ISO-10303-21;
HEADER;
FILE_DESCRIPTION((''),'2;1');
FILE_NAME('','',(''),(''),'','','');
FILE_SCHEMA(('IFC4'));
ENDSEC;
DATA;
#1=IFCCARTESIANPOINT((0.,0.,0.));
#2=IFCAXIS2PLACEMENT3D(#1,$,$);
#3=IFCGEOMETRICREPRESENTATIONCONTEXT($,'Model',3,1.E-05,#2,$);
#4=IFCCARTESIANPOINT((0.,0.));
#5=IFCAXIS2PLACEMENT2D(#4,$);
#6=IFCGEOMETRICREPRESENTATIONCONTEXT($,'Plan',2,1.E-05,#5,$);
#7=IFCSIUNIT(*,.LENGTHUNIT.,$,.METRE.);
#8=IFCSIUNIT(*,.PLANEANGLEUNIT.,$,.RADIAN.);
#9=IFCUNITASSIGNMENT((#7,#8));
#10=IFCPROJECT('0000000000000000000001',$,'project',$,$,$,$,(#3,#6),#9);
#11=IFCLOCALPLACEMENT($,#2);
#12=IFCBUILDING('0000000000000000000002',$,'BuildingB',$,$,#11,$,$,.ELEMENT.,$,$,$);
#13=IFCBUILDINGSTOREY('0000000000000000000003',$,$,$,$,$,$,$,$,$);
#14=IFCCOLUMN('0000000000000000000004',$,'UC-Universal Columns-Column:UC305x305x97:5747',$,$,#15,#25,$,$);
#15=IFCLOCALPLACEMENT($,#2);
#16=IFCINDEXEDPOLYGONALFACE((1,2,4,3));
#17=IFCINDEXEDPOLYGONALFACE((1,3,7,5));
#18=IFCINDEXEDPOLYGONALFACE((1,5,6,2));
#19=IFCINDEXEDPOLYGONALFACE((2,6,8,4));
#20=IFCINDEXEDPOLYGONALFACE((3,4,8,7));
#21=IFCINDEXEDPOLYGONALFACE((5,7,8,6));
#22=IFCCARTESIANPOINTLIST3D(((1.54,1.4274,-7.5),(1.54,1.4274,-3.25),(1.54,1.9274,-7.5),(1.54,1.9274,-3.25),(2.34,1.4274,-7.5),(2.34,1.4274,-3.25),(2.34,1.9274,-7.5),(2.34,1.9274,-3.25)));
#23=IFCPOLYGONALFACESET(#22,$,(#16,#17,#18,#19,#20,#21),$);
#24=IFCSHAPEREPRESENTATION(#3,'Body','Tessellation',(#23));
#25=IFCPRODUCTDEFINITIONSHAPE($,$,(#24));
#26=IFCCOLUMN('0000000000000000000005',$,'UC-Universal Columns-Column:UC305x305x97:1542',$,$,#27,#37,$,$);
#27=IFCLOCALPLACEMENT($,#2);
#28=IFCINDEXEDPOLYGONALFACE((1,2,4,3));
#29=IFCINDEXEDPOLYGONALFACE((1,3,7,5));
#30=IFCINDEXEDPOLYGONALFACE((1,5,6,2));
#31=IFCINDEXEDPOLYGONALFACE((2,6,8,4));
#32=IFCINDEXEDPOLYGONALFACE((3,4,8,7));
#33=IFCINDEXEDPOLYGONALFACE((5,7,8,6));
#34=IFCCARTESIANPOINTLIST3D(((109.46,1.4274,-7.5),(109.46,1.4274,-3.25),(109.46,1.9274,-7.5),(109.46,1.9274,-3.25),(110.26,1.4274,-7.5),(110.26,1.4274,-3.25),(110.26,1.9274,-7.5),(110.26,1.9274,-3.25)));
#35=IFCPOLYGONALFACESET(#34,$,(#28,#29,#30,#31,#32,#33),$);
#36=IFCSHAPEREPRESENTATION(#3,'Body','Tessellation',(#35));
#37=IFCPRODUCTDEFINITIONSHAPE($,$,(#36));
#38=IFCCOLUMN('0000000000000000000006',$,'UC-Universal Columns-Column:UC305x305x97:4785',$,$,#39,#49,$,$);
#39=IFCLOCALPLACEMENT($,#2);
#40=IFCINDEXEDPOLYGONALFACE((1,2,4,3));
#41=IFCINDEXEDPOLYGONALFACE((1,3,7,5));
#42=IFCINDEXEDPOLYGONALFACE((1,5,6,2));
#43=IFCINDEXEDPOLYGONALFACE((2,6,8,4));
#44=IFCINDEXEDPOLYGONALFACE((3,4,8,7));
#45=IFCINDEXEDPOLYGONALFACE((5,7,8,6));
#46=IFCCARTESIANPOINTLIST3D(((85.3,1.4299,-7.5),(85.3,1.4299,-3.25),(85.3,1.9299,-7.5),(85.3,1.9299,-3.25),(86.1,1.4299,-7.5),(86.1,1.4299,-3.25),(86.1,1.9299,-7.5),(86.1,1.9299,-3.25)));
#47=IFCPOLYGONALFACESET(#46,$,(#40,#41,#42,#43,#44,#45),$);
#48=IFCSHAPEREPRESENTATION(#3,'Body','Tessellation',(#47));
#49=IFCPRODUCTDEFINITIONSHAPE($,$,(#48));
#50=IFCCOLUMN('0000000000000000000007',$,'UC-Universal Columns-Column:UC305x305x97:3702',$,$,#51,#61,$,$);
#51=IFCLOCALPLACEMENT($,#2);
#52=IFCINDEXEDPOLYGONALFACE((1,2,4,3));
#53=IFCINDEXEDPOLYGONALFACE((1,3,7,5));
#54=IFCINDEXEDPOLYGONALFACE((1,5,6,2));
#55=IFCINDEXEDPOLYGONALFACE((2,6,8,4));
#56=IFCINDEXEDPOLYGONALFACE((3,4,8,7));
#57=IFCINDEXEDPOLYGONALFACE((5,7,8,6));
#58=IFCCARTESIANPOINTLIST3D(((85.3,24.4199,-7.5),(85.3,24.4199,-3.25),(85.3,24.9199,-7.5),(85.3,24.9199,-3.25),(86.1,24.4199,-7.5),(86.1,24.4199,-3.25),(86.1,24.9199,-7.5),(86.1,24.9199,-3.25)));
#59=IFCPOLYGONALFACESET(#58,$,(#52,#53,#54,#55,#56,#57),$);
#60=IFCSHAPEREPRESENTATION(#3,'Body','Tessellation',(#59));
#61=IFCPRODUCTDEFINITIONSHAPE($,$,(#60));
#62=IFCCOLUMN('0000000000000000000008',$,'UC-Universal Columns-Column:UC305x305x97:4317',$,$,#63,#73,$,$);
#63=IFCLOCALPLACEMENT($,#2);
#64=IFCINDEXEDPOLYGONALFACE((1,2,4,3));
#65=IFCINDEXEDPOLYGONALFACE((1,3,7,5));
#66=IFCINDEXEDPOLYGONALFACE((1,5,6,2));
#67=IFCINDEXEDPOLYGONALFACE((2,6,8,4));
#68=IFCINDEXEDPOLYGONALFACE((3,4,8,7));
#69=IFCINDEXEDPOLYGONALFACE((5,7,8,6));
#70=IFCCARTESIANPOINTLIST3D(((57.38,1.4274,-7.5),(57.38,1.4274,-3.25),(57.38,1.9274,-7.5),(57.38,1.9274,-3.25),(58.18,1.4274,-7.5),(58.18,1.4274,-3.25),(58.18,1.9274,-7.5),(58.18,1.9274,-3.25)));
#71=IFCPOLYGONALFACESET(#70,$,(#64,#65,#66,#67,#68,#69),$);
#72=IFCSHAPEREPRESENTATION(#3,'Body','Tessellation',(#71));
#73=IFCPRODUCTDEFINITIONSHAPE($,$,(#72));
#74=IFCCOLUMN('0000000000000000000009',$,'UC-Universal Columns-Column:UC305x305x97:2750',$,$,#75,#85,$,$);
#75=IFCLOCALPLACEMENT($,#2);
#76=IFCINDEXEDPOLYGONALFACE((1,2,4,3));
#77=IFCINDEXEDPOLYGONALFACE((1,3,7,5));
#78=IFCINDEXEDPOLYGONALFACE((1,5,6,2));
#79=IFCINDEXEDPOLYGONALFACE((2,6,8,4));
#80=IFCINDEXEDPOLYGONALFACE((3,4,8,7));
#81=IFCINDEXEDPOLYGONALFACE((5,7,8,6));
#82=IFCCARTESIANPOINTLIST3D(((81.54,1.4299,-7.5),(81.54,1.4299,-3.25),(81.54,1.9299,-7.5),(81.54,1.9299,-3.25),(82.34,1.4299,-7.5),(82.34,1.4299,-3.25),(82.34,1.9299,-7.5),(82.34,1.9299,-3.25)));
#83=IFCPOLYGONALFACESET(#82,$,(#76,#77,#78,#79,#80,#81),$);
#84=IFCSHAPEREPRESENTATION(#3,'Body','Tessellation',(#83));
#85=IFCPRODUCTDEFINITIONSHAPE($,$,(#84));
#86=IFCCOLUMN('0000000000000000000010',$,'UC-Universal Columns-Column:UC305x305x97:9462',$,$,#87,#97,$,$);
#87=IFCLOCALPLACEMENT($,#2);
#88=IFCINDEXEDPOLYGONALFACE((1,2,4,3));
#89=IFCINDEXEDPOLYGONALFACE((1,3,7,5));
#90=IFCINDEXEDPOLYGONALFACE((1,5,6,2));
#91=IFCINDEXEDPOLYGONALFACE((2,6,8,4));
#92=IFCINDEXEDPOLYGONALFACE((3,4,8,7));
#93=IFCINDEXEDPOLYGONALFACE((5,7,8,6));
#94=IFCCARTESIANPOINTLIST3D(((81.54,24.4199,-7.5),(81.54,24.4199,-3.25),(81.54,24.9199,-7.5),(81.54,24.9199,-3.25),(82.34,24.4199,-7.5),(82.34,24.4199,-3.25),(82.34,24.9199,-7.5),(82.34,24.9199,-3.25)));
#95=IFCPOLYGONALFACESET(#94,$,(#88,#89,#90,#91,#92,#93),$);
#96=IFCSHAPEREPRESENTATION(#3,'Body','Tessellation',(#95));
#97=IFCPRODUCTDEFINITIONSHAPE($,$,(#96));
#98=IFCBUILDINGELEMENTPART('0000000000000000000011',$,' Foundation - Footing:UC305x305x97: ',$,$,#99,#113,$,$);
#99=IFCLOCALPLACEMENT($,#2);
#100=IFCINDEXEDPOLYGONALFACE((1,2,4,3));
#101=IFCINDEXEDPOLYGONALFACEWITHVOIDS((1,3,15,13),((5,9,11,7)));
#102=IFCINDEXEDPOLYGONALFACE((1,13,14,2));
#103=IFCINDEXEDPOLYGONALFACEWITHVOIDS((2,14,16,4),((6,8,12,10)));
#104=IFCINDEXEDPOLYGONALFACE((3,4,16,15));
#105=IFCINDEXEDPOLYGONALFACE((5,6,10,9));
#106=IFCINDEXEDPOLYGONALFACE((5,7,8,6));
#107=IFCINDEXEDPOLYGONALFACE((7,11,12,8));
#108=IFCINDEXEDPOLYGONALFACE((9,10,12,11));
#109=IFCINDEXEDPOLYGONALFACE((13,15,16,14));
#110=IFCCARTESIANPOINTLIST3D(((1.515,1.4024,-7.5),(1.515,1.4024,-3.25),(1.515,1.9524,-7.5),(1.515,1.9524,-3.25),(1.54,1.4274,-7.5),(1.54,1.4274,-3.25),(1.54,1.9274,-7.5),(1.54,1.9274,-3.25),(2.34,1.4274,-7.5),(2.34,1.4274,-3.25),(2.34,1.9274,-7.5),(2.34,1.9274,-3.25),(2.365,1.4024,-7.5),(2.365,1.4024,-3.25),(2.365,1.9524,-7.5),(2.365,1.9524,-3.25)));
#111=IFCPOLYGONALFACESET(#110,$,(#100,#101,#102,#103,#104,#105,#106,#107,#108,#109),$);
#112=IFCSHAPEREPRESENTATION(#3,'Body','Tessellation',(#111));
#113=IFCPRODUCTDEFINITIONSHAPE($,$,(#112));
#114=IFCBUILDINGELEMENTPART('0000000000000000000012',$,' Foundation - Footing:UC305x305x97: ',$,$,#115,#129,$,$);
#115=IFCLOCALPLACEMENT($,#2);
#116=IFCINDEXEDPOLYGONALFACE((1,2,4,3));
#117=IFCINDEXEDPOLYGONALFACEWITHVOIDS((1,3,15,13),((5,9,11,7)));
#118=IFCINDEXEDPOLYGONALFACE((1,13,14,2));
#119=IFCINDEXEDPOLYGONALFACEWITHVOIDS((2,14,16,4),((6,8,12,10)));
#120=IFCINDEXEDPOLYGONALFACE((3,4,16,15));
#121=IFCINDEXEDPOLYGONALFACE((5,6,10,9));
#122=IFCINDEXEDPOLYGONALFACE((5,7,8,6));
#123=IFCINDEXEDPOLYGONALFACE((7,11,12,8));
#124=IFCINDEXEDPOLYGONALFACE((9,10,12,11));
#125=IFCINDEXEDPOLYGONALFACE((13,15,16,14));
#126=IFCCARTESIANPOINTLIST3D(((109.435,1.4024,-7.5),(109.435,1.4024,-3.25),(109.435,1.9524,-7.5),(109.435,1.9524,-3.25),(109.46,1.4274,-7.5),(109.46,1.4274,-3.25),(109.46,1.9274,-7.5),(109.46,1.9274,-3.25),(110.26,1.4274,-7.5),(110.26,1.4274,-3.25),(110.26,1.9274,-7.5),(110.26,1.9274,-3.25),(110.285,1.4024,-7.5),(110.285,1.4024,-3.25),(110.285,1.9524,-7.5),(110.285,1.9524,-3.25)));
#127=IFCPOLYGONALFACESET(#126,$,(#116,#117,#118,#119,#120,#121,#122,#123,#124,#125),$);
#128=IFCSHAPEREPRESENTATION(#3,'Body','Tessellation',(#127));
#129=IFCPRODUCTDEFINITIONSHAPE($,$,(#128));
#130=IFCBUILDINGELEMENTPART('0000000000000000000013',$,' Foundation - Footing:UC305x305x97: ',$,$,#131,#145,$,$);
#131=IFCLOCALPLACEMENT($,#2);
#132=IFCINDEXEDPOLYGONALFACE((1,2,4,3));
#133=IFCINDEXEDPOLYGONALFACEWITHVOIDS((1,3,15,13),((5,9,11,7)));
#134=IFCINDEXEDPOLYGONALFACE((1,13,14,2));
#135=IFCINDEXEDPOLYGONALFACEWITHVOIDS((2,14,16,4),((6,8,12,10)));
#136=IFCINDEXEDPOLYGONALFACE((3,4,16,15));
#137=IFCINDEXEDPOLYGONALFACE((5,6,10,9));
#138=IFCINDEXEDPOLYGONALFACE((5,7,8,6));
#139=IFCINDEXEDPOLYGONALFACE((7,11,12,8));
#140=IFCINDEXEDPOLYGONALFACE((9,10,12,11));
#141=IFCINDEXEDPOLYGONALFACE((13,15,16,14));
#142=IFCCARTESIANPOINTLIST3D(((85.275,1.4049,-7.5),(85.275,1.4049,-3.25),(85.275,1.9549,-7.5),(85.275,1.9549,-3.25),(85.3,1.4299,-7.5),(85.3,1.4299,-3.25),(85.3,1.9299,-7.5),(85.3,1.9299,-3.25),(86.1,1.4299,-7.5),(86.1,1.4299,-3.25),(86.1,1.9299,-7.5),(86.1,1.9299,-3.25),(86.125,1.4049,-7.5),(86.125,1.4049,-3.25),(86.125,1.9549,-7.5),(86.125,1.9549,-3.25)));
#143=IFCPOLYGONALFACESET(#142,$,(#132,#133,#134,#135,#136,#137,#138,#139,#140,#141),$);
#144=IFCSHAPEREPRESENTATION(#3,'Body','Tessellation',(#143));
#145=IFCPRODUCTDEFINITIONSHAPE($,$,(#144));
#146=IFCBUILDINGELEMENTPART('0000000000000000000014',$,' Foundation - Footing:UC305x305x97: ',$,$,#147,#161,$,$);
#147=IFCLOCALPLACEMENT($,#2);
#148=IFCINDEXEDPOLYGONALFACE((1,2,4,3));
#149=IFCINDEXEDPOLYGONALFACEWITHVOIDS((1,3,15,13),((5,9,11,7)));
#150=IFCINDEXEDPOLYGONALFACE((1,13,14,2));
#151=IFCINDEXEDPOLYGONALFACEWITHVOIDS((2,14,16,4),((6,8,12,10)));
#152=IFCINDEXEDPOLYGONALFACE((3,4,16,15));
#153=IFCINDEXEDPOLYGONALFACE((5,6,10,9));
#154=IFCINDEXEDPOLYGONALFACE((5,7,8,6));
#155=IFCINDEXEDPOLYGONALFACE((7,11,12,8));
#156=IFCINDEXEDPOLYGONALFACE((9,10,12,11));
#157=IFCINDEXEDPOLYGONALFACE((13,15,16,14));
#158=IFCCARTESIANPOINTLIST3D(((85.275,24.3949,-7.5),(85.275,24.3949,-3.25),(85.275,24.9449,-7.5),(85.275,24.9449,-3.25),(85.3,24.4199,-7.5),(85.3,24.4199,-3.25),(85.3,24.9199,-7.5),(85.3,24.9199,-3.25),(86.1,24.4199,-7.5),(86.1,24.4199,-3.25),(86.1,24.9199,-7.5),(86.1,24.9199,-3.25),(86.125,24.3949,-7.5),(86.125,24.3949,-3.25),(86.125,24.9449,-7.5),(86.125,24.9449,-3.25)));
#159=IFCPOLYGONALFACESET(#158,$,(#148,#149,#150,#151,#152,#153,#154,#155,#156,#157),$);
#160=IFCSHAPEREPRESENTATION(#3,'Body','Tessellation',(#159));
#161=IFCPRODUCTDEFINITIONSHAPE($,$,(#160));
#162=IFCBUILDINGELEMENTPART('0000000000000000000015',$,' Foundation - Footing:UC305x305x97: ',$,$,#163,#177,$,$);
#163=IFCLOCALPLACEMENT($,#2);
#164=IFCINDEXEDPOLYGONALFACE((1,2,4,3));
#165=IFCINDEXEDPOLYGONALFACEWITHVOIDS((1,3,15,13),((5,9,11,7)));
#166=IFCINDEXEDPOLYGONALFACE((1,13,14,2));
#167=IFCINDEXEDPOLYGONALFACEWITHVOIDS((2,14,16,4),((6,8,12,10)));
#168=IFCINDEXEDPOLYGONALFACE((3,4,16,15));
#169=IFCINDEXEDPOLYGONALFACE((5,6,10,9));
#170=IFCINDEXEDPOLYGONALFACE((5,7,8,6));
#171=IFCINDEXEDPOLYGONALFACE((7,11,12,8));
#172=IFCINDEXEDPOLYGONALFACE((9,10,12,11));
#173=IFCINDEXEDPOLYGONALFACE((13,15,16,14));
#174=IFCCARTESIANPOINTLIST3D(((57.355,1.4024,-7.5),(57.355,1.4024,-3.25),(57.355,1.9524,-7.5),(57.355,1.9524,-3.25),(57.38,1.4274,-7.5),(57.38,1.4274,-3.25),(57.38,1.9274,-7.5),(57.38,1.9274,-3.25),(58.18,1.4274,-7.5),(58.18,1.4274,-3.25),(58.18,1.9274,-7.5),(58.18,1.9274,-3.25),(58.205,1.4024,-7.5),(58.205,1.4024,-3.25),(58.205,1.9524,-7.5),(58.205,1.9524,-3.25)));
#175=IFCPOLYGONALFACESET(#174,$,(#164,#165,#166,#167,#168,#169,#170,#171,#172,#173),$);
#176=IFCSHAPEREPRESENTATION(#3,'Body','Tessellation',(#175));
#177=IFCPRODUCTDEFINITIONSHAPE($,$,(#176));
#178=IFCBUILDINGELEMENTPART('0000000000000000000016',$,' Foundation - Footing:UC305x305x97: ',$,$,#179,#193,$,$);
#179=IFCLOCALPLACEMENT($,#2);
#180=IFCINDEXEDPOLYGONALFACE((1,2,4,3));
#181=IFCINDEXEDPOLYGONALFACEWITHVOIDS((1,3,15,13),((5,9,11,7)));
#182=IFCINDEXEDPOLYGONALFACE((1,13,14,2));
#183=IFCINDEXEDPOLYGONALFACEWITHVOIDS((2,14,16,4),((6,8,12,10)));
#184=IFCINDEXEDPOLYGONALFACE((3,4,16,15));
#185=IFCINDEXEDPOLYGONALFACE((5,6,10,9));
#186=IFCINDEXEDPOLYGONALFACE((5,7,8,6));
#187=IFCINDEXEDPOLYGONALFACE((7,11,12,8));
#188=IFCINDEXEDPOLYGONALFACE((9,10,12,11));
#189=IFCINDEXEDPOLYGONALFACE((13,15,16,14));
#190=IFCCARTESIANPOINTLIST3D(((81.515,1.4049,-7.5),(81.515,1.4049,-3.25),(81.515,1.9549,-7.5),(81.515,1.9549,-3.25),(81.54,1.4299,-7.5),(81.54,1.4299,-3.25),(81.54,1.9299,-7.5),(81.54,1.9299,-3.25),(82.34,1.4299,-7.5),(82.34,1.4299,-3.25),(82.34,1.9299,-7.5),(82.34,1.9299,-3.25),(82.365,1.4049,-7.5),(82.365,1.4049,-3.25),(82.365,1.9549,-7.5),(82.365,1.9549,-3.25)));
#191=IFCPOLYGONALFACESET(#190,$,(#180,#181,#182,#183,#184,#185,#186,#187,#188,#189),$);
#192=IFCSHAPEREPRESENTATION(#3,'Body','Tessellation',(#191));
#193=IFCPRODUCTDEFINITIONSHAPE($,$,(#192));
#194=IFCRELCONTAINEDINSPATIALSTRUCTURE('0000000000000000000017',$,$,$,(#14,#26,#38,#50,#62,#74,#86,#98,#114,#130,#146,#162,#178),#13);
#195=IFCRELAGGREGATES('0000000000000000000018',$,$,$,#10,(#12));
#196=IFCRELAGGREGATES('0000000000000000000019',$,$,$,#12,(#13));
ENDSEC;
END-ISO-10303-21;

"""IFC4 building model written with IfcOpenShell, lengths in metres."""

from ifc_helpers import new_model, si_unit, origin, origin_2d, place, context, project, spatial, polyline, outline, extrude, element, save


model = new_model("IFC4")

# Units and contexts
model_context = context("Model", 3, precision=1e-05, world=origin())
plan_context = context("Plan", 2, precision=1e-05, world=origin_2d())
ifc_project = project(units=[si_unit("LENGTHUNIT", "METRE"), si_unit("PLANEANGLEUNIT", "RADIAN")], contexts=[model_context, plan_context])

# Building, storey
building_placement = place(None, origin())
building = spatial("IfcBuilding", under=ifc_project, at=building_placement, Name="BuildingB", CompositionType="ELEMENT")
storey = spatial("IfcBuildingStorey", under=building)

# Columns
element("IfcColumn", 1, inside=storey, Name="UC-Universal Columns-Column:UC305x305x97:5747", context=model_context, shape_type="SweptSolid", body=[
    extrude(outline(polyline([(1.54, 1.4274, -7.5), (2.34, 1.4274, -7.5), (2.34, 1.9274, -7.5), (1.54, 1.9274, -7.5), (1.54, 1.4274, -7.5)])), None, (0.0, 0.0, 1.0), 4.25),
])
element("IfcColumn", 2, inside=storey, Name="UC-Universal Columns-Column:UC305x305x97:1542", context=model_context, shape_type="SweptSolid", body=[
    extrude(outline(polyline([(110.26, 1.4274, -7.5), (109.46, 1.4274, -7.5), (109.46, 1.9274, -7.5), (110.26, 1.9274, -7.5), (110.26, 1.4274, -7.5)])), None, (0.0, 0.0, 1.0), 4.25),
])
element("IfcColumn", 3, inside=storey, Name="UC-Universal Columns-Column:UC305x305x97:4785", context=model_context, shape_type="SweptSolid", body=[
    extrude(outline(polyline([(86.1, 1.4299, -7.5), (85.3, 1.4299, -7.5), (85.3, 1.9299, -7.5), (86.1, 1.9299, -7.5), (86.1, 1.4299, -7.5)])), None, (0.0, 0.0, 1.0), 4.25),
])
element("IfcColumn", 4, inside=storey, Name="UC-Universal Columns-Column:UC305x305x97:3702", context=model_context, shape_type="SweptSolid", body=[
    extrude(outline(polyline([(86.1, 24.4199, -7.5), (85.3, 24.4199, -7.5), (85.3, 24.9199, -7.5), (86.1, 24.9199, -7.5), (86.1, 24.4199, -7.5)])), None, (0.0, 0.0, 1.0), 4.25),
])
element("IfcColumn", 5, inside=storey, Name="UC-Universal Columns-Column:UC305x305x97:4317", context=model_context, shape_type="SweptSolid", body=[
    extrude(outline(polyline([(57.38, 1.4274, -7.5), (58.18, 1.4274, -7.5), (58.18, 1.9274, -7.5), (57.38, 1.9274, -7.5), (57.38, 1.4274, -7.5)])), None, (0.0, 0.0, 1.0), 4.25),
])
element("IfcColumn", 6, inside=storey, Name="UC-Universal Columns-Column:UC305x305x97:2750", context=model_context, shape_type="SweptSolid", body=[
    extrude(outline(polyline([(81.54, 1.4299, -7.5), (82.34, 1.4299, -7.5), (82.34, 1.9299, -7.5), (81.54, 1.9299, -7.5), (81.54, 1.4299, -7.5)])), None, (0.0, 0.0, 1.0), 4.25),
])
element("IfcColumn", 7, inside=storey, Name="UC-Universal Columns-Column:UC305x305x97:9462", context=model_context, shape_type="SweptSolid", body=[
    extrude(outline(polyline([(81.54, 24.4199, -7.5), (82.34, 24.4199, -7.5), (82.34, 24.9199, -7.5), (81.54, 24.9199, -7.5), (81.54, 24.4199, -7.5)])), None, (0.0, 0.0, 1.0), 4.25),
])

# Building element parts, openings
building_element_part_1 = element("IfcBuildingElementPart", 8, inside=storey, Name=" Foundation - Footing:UC305x305x97: ", context=model_context, shape_type="SweptSolid", body=[
    extrude(outline(polyline([(1.515, 1.4024, -7.5), (2.365, 1.4024, -7.5), (2.365, 1.9524, -7.5), (1.515, 1.9524, -7.5), (1.515, 1.4024, -7.5)])), None, (0.0, 0.0, 1.0), 4.25),
])
element("IfcOpeningElement", 9, inside=storey, cuts=building_element_part_1, context=model_context, shape_type="SweptSolid", body=[
    extrude(outline(polyline([(1.54, 1.4274, -7.5), (2.34, 1.4274, -7.5), (2.34, 1.9274, -7.5), (1.54, 1.9274, -7.5), (1.54, 1.4274, -7.5)])), None, (0.0, 0.0, 1.0), 4.25),
])
building_element_part_2 = element("IfcBuildingElementPart", 10, inside=storey, Name=" Foundation - Footing:UC305x305x97: ", context=model_context, shape_type="SweptSolid", body=[
    extrude(outline(polyline([(110.285, 1.4024, -7.5), (109.435, 1.4024, -7.5), (109.435, 1.9524, -7.5), (110.285, 1.9524, -7.5), (110.285, 1.4024, -7.5)])), None, (0.0, 0.0, 1.0), 4.25),
])
element("IfcOpeningElement", 11, inside=storey, cuts=building_element_part_2, context=model_context, shape_type="SweptSolid", body=[
    extrude(outline(polyline([(110.26, 1.4274, -7.5), (109.46, 1.4274, -7.5), (109.46, 1.9274, -7.5), (110.26, 1.9274, -7.5), (110.26, 1.4274, -7.5)])), None, (0.0, 0.0, 1.0), 4.25),
])
building_element_part_3 = element("IfcBuildingElementPart", 12, inside=storey, Name=" Foundation - Footing:UC305x305x97: ", context=model_context, shape_type="SweptSolid", body=[
    extrude(outline(polyline([(86.125, 1.4049, -7.5), (85.275, 1.4049, -7.5), (85.275, 1.9549, -7.5), (86.125, 1.9549, -7.5), (86.125, 1.4049, -7.5)])), None, (0.0, 0.0, 1.0), 4.25),
])
element("IfcOpeningElement", 13, inside=storey, cuts=building_element_part_3, context=model_context, shape_type="SweptSolid", body=[
    extrude(outline(polyline([(86.1, 1.4299, -7.5), (85.3, 1.4299, -7.5), (85.3, 1.9299, -7.5), (86.1, 1.9299, -7.5), (86.1, 1.4299, -7.5)])), None, (0.0, 0.0, 1.0), 4.25),
])
building_element_part_4 = element("IfcBuildingElementPart", 14, inside=storey, Name=" Foundation - Footing:UC305x305x97: ", context=model_context, shape_type="SweptSolid", body=[
    extrude(outline(polyline([(86.125, 24.3949, -7.5), (85.275, 24.3949, -7.5), (85.275, 24.9449, -7.5), (86.125, 24.9449, -7.5), (86.125, 24.3949, -7.5)])), None, (0.0, 0.0, 1.0), 4.25),
])
element("IfcOpeningElement", 15, inside=storey, cuts=building_element_part_4, context=model_context, shape_type="SweptSolid", body=[
    extrude(outline(polyline([(86.1, 24.4199, -7.5), (85.3, 24.4199, -7.5), (85.3, 24.9199, -7.5), (86.1, 24.9199, -7.5), (86.1, 24.4199, -7.5)])), None, (0.0, 0.0, 1.0), 4.25),
])
building_element_part_5 = element("IfcBuildingElementPart", 16, inside=storey, Name=" Foundation - Footing:UC305x305x97: ", context=model_context, shape_type="SweptSolid", body=[
    extrude(outline(polyline([(57.355, 1.4024, -7.5), (58.205, 1.4024, -7.5), (58.205, 1.9524, -7.5), (57.355, 1.9524, -7.5), (57.355, 1.4024, -7.5)])), None, (0.0, 0.0, 1.0), 4.25),
])
element("IfcOpeningElement", 17, inside=storey, cuts=building_element_part_5, context=model_context, shape_type="SweptSolid", body=[
    extrude(outline(polyline([(57.38, 1.4274, -7.5), (58.18, 1.4274, -7.5), (58.18, 1.9274, -7.5), (57.38, 1.9274, -7.5), (57.38, 1.4274, -7.5)])), None, (0.0, 0.0, 1.0), 4.25),
])
building_element_part_6 = element("IfcBuildingElementPart", 18, inside=storey, Name=" Foundation - Footing:UC305x305x97: ", context=model_context, shape_type="SweptSolid", body=[
    extrude(outline(polyline([(81.515, 1.4049, -7.5), (82.365, 1.4049, -7.5), (82.365, 1.9549, -7.5), (81.515, 1.9549, -7.5), (81.515, 1.4049, -7.5)])), None, (0.0, 0.0, 1.0), 4.25),
])
element("IfcOpeningElement", 19, inside=storey, cuts=building_element_part_6, context=model_context, shape_type="SweptSolid", body=[
    extrude(outline(polyline([(81.54, 1.4299, -7.5), (82.34, 1.4299, -7.5), (82.34, 1.9299, -7.5), (81.54, 1.9299, -7.5), (81.54, 1.4299, -7.5)])), None, (0.0, 0.0, 1.0), 4.25),
])

save(model, "model.ifc")
